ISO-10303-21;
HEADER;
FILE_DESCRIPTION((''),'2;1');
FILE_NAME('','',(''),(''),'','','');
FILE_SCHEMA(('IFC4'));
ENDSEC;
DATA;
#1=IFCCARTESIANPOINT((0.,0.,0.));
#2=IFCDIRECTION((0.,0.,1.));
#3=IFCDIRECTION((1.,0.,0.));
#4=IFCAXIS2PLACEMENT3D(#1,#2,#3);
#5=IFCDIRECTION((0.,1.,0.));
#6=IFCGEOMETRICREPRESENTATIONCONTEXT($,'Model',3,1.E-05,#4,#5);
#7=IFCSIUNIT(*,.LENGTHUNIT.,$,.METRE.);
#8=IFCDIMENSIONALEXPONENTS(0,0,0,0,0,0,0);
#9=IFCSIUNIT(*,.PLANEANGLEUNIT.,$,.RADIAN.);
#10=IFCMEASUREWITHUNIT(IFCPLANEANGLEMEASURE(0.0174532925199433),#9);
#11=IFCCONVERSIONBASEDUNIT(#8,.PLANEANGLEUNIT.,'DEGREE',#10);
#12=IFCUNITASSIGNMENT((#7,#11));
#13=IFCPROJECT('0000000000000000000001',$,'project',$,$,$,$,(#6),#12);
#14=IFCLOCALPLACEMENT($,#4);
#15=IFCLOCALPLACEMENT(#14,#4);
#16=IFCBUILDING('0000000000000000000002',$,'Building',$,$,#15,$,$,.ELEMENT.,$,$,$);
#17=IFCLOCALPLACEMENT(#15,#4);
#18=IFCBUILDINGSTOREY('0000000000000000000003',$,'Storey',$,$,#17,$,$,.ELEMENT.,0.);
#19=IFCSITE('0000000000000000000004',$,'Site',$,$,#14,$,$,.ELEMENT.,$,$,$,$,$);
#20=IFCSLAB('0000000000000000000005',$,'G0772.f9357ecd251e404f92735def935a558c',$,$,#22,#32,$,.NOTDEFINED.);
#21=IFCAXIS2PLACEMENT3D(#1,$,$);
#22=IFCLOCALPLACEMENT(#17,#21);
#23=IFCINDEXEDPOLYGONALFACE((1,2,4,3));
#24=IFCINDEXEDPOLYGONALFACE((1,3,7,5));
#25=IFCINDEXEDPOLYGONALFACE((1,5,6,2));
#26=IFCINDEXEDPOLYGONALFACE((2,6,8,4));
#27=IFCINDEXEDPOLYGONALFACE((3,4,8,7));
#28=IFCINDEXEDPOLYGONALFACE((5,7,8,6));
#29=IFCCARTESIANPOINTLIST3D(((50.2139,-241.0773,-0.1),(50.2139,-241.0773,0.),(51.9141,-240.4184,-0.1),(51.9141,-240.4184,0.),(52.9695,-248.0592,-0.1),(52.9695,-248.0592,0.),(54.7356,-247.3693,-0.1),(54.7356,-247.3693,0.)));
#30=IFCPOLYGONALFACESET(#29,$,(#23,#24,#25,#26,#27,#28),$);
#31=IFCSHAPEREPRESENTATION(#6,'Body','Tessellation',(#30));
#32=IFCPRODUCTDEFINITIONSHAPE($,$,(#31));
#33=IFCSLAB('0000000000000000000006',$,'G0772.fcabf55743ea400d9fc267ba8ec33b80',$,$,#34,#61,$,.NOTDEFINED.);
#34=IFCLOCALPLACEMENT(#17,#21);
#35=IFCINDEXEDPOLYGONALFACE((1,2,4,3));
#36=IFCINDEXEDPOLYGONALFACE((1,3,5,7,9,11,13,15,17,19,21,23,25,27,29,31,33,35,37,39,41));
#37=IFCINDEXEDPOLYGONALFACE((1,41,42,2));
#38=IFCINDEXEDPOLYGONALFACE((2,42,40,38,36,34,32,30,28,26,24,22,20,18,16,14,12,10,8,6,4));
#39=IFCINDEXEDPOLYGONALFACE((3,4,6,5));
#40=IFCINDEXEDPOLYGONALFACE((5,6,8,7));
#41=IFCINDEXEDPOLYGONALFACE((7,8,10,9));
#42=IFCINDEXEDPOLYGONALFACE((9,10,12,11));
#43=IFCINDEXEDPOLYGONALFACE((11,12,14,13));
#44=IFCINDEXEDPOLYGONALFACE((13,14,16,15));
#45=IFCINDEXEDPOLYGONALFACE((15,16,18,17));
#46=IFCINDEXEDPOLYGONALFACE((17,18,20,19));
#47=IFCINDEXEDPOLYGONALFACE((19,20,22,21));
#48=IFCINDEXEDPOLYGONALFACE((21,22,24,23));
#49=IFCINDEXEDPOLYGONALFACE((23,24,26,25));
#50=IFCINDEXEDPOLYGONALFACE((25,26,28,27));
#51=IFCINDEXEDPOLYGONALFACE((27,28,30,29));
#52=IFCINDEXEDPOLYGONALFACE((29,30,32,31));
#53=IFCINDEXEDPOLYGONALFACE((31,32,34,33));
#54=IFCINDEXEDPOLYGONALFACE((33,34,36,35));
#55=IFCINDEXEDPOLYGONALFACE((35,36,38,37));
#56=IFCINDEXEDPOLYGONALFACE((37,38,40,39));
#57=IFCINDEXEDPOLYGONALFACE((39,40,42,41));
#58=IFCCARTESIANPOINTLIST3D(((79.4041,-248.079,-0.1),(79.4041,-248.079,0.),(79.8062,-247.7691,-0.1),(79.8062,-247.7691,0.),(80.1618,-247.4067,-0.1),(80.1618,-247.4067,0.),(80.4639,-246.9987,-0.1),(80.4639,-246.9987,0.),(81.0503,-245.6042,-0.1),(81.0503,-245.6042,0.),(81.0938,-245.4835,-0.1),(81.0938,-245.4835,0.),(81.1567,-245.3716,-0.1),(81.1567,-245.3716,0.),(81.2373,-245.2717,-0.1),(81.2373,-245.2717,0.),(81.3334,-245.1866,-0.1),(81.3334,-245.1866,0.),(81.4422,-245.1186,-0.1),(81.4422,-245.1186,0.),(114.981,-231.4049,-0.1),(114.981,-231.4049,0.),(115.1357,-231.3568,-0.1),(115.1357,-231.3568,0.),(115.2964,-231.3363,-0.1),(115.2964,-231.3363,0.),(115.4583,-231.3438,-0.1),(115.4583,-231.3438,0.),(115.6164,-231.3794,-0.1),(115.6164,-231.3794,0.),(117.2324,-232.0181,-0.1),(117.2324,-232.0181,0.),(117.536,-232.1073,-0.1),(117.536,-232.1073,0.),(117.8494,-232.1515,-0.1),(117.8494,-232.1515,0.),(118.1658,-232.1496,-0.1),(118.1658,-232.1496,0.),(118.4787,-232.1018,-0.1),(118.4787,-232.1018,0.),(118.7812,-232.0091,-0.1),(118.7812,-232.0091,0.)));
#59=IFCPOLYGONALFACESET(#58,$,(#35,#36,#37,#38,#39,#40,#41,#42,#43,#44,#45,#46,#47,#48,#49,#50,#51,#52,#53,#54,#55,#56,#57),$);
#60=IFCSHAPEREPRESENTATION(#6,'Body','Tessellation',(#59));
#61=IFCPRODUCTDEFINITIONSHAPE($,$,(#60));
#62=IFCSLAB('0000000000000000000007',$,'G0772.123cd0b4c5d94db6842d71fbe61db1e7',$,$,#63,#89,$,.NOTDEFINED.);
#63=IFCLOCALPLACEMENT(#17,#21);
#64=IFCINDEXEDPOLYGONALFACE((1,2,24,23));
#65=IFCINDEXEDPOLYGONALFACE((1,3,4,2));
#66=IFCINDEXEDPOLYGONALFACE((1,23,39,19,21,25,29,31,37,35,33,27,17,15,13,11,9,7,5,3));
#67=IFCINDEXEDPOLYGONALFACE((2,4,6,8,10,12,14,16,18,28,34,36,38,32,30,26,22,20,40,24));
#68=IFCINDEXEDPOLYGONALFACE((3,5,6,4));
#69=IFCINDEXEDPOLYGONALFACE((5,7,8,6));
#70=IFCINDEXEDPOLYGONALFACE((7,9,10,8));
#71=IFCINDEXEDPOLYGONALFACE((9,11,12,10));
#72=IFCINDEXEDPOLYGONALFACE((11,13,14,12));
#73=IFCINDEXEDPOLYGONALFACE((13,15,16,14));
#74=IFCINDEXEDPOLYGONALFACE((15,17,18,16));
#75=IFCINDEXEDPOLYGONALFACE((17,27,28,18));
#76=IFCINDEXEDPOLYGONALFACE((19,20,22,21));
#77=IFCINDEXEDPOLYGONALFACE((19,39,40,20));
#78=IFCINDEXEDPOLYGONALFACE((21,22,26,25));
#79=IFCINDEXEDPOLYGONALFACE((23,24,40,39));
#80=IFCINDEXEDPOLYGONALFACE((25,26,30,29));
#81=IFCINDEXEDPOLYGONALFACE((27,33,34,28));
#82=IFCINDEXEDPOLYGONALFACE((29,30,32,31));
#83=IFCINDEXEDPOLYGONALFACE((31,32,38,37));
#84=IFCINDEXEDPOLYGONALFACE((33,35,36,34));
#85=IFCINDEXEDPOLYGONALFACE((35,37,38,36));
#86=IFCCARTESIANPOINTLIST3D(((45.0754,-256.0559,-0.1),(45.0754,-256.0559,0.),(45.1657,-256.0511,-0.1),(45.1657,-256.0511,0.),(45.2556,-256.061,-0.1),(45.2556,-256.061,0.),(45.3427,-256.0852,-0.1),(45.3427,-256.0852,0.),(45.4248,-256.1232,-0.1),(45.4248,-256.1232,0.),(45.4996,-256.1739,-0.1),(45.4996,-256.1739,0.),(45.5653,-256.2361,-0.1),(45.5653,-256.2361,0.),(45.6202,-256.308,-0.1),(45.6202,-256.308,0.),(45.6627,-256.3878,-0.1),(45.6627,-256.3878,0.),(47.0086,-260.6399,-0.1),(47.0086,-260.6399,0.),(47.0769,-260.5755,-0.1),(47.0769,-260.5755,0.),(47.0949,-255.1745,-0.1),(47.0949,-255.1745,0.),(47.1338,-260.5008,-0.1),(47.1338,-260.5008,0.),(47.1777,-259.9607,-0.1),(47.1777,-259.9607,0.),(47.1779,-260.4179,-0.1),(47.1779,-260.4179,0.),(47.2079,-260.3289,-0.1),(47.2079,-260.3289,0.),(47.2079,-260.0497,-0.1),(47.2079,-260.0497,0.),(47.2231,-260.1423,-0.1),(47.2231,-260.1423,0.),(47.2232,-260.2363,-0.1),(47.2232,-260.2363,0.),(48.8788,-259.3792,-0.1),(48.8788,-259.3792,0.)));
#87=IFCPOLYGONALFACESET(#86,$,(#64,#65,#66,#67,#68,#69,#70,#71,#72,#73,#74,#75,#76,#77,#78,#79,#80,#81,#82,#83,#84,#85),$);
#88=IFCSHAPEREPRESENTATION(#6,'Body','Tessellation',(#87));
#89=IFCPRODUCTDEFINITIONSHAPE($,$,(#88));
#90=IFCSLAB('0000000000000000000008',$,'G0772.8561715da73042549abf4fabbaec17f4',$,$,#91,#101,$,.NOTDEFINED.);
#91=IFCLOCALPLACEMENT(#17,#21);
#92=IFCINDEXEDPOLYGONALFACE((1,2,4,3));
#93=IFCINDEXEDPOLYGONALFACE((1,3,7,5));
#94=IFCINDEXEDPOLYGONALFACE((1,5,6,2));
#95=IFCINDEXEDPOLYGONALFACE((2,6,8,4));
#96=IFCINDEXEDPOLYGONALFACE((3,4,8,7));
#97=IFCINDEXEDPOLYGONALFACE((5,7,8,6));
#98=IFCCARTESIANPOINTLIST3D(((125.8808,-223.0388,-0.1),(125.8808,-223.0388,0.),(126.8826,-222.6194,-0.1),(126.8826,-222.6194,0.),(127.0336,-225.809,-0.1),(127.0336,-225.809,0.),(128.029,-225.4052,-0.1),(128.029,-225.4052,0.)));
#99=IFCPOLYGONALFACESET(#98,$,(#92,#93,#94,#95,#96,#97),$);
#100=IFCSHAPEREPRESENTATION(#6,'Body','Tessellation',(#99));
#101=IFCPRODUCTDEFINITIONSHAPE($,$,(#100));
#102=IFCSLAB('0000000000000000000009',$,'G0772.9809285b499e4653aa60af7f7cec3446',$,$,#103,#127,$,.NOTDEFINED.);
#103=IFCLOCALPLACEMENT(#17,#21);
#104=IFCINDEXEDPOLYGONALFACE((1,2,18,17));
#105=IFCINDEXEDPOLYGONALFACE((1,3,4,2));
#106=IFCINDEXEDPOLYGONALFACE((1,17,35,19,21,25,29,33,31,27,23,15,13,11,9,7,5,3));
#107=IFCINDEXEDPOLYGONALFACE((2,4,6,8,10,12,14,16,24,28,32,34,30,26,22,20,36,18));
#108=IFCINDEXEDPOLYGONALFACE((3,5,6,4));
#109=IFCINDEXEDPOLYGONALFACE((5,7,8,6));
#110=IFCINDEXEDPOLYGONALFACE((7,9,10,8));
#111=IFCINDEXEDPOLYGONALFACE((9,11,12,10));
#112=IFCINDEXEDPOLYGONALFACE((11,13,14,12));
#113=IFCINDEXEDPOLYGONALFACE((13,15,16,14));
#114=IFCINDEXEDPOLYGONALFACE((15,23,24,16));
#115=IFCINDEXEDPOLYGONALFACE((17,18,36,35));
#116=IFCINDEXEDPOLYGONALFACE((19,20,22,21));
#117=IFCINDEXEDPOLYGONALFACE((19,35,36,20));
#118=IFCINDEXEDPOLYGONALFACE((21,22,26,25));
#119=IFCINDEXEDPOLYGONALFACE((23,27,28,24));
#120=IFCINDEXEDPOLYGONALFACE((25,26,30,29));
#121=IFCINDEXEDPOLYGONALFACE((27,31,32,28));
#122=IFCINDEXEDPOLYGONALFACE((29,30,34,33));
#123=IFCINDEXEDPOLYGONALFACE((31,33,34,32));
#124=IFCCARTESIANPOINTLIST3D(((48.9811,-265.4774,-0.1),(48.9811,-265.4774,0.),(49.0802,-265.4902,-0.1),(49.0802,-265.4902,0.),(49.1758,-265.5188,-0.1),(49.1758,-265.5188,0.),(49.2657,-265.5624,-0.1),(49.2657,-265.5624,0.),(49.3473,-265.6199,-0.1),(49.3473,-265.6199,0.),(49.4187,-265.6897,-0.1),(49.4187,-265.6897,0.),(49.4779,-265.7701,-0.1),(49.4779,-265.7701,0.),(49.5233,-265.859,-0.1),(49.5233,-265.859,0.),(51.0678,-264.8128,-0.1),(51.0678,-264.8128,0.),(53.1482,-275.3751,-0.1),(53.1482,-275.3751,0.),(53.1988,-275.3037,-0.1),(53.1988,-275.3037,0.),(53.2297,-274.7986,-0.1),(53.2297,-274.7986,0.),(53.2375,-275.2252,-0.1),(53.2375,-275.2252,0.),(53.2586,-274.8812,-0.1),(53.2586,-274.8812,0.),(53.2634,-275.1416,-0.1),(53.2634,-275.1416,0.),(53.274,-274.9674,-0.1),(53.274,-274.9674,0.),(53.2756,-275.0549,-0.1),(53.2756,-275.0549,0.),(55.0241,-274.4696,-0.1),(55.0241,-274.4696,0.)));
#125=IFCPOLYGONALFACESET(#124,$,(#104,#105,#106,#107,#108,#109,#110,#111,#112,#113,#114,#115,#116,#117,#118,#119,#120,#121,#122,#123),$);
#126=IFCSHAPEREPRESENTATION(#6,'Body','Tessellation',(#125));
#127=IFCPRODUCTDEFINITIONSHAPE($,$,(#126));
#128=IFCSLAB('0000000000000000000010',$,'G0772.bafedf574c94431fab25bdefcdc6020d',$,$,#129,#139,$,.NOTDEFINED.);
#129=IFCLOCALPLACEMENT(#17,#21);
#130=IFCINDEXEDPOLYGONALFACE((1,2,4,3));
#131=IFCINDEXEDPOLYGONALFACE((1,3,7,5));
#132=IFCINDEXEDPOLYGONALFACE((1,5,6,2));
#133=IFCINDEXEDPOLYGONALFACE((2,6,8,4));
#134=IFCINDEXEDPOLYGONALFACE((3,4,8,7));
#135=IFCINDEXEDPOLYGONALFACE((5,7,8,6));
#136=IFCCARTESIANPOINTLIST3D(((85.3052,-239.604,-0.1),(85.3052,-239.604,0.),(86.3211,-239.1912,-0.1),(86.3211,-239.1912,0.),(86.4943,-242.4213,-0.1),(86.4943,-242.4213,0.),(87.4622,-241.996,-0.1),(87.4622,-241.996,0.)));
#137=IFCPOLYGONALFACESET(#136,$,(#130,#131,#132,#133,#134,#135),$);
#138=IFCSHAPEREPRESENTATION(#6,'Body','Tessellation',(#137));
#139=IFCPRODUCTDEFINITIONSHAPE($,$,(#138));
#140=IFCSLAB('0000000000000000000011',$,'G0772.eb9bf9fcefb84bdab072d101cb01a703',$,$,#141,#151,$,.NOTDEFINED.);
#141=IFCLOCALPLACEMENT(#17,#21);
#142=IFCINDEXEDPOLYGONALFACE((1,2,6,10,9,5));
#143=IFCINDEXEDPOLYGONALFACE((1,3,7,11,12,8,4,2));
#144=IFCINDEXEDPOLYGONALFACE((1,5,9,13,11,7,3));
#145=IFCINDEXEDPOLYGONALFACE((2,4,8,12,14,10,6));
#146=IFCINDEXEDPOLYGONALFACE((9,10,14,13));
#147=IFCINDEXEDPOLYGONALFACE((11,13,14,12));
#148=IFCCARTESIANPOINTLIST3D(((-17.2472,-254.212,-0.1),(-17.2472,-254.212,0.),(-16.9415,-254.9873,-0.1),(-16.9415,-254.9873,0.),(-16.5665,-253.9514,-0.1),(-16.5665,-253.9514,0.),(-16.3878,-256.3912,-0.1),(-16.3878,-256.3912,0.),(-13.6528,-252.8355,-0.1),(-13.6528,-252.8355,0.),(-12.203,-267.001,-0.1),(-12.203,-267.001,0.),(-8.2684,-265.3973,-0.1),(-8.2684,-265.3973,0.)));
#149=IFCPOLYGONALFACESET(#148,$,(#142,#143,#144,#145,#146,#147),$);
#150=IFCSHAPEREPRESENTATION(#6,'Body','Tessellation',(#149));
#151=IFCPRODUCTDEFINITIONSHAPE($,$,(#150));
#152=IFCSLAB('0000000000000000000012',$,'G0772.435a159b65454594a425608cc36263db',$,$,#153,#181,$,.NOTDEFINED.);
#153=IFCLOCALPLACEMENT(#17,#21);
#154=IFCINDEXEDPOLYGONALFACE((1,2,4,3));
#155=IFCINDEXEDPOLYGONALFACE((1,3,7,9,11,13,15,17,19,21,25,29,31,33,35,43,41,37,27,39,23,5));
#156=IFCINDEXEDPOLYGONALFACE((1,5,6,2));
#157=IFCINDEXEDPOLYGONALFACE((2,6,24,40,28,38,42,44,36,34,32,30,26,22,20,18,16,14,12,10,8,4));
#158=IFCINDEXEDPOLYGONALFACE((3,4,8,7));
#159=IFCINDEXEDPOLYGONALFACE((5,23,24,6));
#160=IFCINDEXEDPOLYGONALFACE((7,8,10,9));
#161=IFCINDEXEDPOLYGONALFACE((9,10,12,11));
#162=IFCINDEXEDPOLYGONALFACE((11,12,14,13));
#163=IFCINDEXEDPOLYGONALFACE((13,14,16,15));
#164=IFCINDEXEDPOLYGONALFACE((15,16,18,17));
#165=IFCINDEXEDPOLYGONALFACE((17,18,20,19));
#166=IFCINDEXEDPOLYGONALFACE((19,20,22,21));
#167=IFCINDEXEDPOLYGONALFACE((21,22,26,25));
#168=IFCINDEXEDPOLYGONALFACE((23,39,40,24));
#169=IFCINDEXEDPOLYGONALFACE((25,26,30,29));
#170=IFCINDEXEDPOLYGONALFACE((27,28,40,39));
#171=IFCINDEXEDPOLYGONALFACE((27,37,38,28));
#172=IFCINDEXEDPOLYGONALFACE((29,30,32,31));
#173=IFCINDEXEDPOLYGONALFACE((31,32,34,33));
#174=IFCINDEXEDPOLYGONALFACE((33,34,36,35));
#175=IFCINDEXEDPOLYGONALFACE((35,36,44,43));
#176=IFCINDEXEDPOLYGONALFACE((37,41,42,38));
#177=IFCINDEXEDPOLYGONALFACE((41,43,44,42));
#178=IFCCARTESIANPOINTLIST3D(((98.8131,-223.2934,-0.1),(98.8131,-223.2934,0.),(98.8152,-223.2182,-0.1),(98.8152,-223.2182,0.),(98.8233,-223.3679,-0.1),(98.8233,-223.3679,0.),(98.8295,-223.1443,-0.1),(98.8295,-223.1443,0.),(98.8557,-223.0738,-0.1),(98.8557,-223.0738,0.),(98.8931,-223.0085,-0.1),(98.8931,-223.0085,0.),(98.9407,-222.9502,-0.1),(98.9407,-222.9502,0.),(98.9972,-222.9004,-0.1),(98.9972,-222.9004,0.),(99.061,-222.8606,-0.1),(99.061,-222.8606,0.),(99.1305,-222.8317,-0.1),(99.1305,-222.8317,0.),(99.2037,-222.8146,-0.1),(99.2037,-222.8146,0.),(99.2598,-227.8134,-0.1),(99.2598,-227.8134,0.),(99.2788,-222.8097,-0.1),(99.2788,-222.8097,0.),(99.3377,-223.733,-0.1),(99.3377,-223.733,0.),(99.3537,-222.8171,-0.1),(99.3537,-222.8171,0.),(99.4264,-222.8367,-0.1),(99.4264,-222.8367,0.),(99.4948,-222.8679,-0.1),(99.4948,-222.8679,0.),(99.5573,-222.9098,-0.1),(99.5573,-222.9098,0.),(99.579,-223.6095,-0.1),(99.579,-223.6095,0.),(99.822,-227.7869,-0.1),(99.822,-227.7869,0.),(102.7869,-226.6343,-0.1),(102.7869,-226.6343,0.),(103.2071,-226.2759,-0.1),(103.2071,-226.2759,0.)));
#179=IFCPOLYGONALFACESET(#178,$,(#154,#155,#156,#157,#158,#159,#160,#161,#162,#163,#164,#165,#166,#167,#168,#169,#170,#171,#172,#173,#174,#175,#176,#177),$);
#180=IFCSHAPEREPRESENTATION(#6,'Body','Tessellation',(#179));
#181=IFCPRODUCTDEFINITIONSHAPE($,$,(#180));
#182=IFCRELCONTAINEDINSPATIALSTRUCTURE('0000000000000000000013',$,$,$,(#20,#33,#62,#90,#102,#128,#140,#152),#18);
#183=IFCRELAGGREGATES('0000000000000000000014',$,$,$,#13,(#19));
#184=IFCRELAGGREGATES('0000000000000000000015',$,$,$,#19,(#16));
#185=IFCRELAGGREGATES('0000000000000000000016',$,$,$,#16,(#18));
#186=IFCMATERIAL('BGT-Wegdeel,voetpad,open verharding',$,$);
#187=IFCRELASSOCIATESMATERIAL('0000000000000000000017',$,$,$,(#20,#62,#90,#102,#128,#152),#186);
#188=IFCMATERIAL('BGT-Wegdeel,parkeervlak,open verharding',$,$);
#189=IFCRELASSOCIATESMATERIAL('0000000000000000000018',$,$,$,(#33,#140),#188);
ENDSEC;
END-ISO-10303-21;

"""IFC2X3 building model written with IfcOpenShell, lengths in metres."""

from ifc_helpers import new_model, entity, si_unit, converted_unit, direction, frame, origin_with_axes, place, context, project, spatial, polyline, outline, extrude, material, element, save


model = new_model("IFC2X3")

# Units and contexts
model_context = context("Model", 3, precision=1e-05, world=origin_with_axes(), true_north=direction((0.0, 1.0, 0.0)))
ifc_project = project(units=[si_unit("LENGTHUNIT", "METRE"), converted_unit("PLANEANGLEUNIT", "DEGREE", entity("IfcPlaneAngleMeasure", 0.0174532925199433), si_unit("PLANEANGLEUNIT", "RADIAN"), dimensions=[0, 0, 0, 0, 0, 0, 0])], contexts=[model_context])

# Site, building, storey
site_placement = place(None, origin_with_axes())
site = spatial("IfcSite", under=ifc_project, at=site_placement, Name="Site", CompositionType="ELEMENT")
building_placement = place(site_placement, origin_with_axes())
building = spatial("IfcBuilding", under=site, at=building_placement, Name="Building", CompositionType="ELEMENT")
storey_placement = place(building_placement, origin_with_axes())
storey = spatial("IfcBuildingStorey", under=building, at=storey_placement, Name="Storey", CompositionType="ELEMENT", Elevation=0.0)

# Slabs
ifc_material_1 = material(Name="BGT-Wegdeel,voetpad,open verharding")
slab_1_placement = place(storey_placement, frame((0.0, 0.0, -0.1), z_axis=(0.0, 0.0, 1.0), x_axis=(1.0, 0.0, 0.0)))
element("IfcSlab", 1, at=slab_1_placement, inside=storey, material=ifc_material_1, Name="G0772.f9357ecd251e404f92735def935a558c", PredefinedType="NOTDEFINED", context=model_context, shape_type="SweptSolid", body=[
    extrude(outline(polyline([(54.7356, -247.3693), (52.9695, -248.0592), (50.2139, -241.0773), (51.9141, -240.4184), (54.7356, -247.3693)])), origin_with_axes(), (0.0, 0.0, 1.0), 0.1),
])
ifc_material_2 = material(Name="BGT-Wegdeel,parkeervlak,open verharding")
slab_2_placement = place(storey_placement, frame((0.0, 0.0, -0.1), z_axis=(0.0, 0.0, 1.0), x_axis=(1.0, 0.0, 0.0)))
element("IfcSlab", 2, at=slab_2_placement, inside=storey, material=ifc_material_2, Name="G0772.fcabf55743ea400d9fc267ba8ec33b80", PredefinedType="NOTDEFINED", context=model_context, shape_type="SweptSolid", body=[
    extrude(outline(polyline([(81.0938, -245.4835), (81.1567, -245.3716), (81.2373, -245.2717), (81.3334, -245.1866), (81.4422, -245.1186), (114.981, -231.4049), (115.1357, -231.3568), (115.2964, -231.3363), (115.4583, -231.3438), (115.6164, -231.3794), (117.2324, -232.0181), (117.536, -232.1073), (117.8494, -232.1515), (118.1658, -232.1496), (118.4787, -232.1018), (118.7812, -232.0091), (79.4041, -248.079), (79.8062, -247.7691), (80.1618, -247.4067), (80.4639, -246.9987), (81.0503, -245.6042), (81.0938, -245.4835)])), origin_with_axes(), (0.0, 0.0, 1.0), 0.1),
])
slab_3_placement = place(storey_placement, frame((0.0, 0.0, -0.1), z_axis=(0.0, 0.0, 1.0), x_axis=(1.0, 0.0, 0.0)))
element("IfcSlab", 3, at=slab_3_placement, inside=storey, material=ifc_material_1, Name="G0772.123cd0b4c5d94db6842d71fbe61db1e7", PredefinedType="NOTDEFINED", context=model_context, shape_type="SweptSolid", body=[
    extrude(outline(polyline([(45.6202, -256.308), (45.5653, -256.2361), (45.4996, -256.1739), (45.4248, -256.1232), (45.3427, -256.0852), (45.2556, -256.061), (45.1657, -256.0511), (45.0754, -256.0559), (47.0949, -255.1745), (48.8788, -259.3792), (47.0086, -260.6399), (47.0769, -260.5755), (47.1338, -260.5008), (47.1779, -260.4179), (47.2079, -260.3289), (47.2232, -260.2363), (47.2231, -260.1423), (47.2079, -260.0497), (47.1777, -259.9607), (45.6627, -256.3878), (45.6202, -256.308)])), origin_with_axes(), (0.0, 0.0, 1.0), 0.1),
])
slab_4_placement = place(storey_placement, frame((0.0, 0.0, -0.1), z_axis=(0.0, 0.0, 1.0), x_axis=(1.0, 0.0, 0.0)))
element("IfcSlab", 4, at=slab_4_placement, inside=storey, material=ifc_material_1, Name="G0772.8561715da73042549abf4fabbaec17f4", PredefinedType="NOTDEFINED", context=model_context, shape_type="SweptSolid", body=[
    extrude(outline(polyline([(125.8808, -223.0388), (126.8826, -222.6194), (128.029, -225.4052), (127.0336, -225.809), (125.8808, -223.0388)])), origin_with_axes(), (0.0, 0.0, 1.0), 0.1),
])
slab_5_placement = place(storey_placement, frame((0.0, 0.0, -0.1), z_axis=(0.0, 0.0, 1.0), x_axis=(1.0, 0.0, 0.0)))
element("IfcSlab", 5, at=slab_5_placement, inside=storey, material=ifc_material_1, Name="G0772.9809285b499e4653aa60af7f7cec3446", PredefinedType="NOTDEFINED", context=model_context, shape_type="SweptSolid", body=[
    extrude(outline(polyline([(49.5233, -265.859), (49.4779, -265.7701), (49.4187, -265.6897), (49.3473, -265.6199), (49.2657, -265.5624), (49.1758, -265.5188), (49.0802, -265.4902), (48.9811, -265.4774), (51.0678, -264.8128), (55.0241, -274.4696), (53.1482, -275.3751), (53.1988, -275.3037), (53.2375, -275.2252), (53.2634, -275.1416), (53.2756, -275.0549), (53.274, -274.9674), (53.2586, -274.8812), (53.2297, -274.7986), (49.5233, -265.859)])), origin_with_axes(), (0.0, 0.0, 1.0), 0.1),
])
slab_6_placement = place(storey_placement, frame((0.0, 0.0, -0.1), z_axis=(0.0, 0.0, 1.0), x_axis=(1.0, 0.0, 0.0)))
element("IfcSlab", 6, at=slab_6_placement, inside=storey, material=ifc_material_1, Name="G0772.bafedf574c94431fab25bdefcdc6020d", PredefinedType="NOTDEFINED", context=model_context, shape_type="SweptSolid", body=[
    extrude(outline(polyline([(85.3052, -239.604), (86.3211, -239.1912), (87.4622, -241.996), (86.4943, -242.4213), (85.3052, -239.604)])), origin_with_axes(), (0.0, 0.0, 1.0), 0.1),
])
slab_7_placement = place(storey_placement, frame((0.0, 0.0, -0.1), z_axis=(0.0, 0.0, 1.0), x_axis=(1.0, 0.0, 0.0)))
element("IfcSlab", 7, at=slab_7_placement, inside=storey, material=ifc_material_2, Name="G0772.eb9bf9fcefb84bdab072d101cb01a703", PredefinedType="NOTDEFINED", context=model_context, shape_type="SweptSolid", body=[
    extrude(outline(polyline([(-16.9415, -254.9873), (-17.2472, -254.212), (-16.5665, -253.9514), (-13.6528, -252.8355), (-8.2684, -265.3973), (-12.203, -267.001), (-16.3878, -256.3912), (-16.9415, -254.9873)])), origin_with_axes(), (0.0, 0.0, 1.0), 0.1),
])
slab_8_placement = place(storey_placement, frame((0.0, 0.0, -0.1), z_axis=(0.0, 0.0, 1.0), x_axis=(1.0, 0.0, 0.0)))
element("IfcSlab", 8, at=slab_8_placement, inside=storey, material=ifc_material_1, Name="G0772.435a159b65454594a425608cc36263db", PredefinedType="NOTDEFINED", context=model_context, shape_type="SweptSolid", body=[
    extrude(outline(polyline([(98.8233, -223.3679), (98.8131, -223.2934), (98.8152, -223.2182), (98.8295, -223.1443), (98.8557, -223.0738), (98.8931, -223.0085), (98.9407, -222.9502), (98.9972, -222.9004), (99.061, -222.8606), (99.1305, -222.8317), (99.2037, -222.8146), (99.2788, -222.8097), (99.3537, -222.8171), (99.4264, -222.8367), (99.4948, -222.8679), (99.5573, -222.9098), (103.2071, -226.2759), (102.7869, -226.6343), (99.579, -223.6095), (99.3377, -223.733), (99.822, -227.7869), (99.2598, -227.8134), (98.8233, -223.3679)])), origin_with_axes(), (0.0, 0.0, 1.0), 0.1),
])

save(model, "model.ifc")
